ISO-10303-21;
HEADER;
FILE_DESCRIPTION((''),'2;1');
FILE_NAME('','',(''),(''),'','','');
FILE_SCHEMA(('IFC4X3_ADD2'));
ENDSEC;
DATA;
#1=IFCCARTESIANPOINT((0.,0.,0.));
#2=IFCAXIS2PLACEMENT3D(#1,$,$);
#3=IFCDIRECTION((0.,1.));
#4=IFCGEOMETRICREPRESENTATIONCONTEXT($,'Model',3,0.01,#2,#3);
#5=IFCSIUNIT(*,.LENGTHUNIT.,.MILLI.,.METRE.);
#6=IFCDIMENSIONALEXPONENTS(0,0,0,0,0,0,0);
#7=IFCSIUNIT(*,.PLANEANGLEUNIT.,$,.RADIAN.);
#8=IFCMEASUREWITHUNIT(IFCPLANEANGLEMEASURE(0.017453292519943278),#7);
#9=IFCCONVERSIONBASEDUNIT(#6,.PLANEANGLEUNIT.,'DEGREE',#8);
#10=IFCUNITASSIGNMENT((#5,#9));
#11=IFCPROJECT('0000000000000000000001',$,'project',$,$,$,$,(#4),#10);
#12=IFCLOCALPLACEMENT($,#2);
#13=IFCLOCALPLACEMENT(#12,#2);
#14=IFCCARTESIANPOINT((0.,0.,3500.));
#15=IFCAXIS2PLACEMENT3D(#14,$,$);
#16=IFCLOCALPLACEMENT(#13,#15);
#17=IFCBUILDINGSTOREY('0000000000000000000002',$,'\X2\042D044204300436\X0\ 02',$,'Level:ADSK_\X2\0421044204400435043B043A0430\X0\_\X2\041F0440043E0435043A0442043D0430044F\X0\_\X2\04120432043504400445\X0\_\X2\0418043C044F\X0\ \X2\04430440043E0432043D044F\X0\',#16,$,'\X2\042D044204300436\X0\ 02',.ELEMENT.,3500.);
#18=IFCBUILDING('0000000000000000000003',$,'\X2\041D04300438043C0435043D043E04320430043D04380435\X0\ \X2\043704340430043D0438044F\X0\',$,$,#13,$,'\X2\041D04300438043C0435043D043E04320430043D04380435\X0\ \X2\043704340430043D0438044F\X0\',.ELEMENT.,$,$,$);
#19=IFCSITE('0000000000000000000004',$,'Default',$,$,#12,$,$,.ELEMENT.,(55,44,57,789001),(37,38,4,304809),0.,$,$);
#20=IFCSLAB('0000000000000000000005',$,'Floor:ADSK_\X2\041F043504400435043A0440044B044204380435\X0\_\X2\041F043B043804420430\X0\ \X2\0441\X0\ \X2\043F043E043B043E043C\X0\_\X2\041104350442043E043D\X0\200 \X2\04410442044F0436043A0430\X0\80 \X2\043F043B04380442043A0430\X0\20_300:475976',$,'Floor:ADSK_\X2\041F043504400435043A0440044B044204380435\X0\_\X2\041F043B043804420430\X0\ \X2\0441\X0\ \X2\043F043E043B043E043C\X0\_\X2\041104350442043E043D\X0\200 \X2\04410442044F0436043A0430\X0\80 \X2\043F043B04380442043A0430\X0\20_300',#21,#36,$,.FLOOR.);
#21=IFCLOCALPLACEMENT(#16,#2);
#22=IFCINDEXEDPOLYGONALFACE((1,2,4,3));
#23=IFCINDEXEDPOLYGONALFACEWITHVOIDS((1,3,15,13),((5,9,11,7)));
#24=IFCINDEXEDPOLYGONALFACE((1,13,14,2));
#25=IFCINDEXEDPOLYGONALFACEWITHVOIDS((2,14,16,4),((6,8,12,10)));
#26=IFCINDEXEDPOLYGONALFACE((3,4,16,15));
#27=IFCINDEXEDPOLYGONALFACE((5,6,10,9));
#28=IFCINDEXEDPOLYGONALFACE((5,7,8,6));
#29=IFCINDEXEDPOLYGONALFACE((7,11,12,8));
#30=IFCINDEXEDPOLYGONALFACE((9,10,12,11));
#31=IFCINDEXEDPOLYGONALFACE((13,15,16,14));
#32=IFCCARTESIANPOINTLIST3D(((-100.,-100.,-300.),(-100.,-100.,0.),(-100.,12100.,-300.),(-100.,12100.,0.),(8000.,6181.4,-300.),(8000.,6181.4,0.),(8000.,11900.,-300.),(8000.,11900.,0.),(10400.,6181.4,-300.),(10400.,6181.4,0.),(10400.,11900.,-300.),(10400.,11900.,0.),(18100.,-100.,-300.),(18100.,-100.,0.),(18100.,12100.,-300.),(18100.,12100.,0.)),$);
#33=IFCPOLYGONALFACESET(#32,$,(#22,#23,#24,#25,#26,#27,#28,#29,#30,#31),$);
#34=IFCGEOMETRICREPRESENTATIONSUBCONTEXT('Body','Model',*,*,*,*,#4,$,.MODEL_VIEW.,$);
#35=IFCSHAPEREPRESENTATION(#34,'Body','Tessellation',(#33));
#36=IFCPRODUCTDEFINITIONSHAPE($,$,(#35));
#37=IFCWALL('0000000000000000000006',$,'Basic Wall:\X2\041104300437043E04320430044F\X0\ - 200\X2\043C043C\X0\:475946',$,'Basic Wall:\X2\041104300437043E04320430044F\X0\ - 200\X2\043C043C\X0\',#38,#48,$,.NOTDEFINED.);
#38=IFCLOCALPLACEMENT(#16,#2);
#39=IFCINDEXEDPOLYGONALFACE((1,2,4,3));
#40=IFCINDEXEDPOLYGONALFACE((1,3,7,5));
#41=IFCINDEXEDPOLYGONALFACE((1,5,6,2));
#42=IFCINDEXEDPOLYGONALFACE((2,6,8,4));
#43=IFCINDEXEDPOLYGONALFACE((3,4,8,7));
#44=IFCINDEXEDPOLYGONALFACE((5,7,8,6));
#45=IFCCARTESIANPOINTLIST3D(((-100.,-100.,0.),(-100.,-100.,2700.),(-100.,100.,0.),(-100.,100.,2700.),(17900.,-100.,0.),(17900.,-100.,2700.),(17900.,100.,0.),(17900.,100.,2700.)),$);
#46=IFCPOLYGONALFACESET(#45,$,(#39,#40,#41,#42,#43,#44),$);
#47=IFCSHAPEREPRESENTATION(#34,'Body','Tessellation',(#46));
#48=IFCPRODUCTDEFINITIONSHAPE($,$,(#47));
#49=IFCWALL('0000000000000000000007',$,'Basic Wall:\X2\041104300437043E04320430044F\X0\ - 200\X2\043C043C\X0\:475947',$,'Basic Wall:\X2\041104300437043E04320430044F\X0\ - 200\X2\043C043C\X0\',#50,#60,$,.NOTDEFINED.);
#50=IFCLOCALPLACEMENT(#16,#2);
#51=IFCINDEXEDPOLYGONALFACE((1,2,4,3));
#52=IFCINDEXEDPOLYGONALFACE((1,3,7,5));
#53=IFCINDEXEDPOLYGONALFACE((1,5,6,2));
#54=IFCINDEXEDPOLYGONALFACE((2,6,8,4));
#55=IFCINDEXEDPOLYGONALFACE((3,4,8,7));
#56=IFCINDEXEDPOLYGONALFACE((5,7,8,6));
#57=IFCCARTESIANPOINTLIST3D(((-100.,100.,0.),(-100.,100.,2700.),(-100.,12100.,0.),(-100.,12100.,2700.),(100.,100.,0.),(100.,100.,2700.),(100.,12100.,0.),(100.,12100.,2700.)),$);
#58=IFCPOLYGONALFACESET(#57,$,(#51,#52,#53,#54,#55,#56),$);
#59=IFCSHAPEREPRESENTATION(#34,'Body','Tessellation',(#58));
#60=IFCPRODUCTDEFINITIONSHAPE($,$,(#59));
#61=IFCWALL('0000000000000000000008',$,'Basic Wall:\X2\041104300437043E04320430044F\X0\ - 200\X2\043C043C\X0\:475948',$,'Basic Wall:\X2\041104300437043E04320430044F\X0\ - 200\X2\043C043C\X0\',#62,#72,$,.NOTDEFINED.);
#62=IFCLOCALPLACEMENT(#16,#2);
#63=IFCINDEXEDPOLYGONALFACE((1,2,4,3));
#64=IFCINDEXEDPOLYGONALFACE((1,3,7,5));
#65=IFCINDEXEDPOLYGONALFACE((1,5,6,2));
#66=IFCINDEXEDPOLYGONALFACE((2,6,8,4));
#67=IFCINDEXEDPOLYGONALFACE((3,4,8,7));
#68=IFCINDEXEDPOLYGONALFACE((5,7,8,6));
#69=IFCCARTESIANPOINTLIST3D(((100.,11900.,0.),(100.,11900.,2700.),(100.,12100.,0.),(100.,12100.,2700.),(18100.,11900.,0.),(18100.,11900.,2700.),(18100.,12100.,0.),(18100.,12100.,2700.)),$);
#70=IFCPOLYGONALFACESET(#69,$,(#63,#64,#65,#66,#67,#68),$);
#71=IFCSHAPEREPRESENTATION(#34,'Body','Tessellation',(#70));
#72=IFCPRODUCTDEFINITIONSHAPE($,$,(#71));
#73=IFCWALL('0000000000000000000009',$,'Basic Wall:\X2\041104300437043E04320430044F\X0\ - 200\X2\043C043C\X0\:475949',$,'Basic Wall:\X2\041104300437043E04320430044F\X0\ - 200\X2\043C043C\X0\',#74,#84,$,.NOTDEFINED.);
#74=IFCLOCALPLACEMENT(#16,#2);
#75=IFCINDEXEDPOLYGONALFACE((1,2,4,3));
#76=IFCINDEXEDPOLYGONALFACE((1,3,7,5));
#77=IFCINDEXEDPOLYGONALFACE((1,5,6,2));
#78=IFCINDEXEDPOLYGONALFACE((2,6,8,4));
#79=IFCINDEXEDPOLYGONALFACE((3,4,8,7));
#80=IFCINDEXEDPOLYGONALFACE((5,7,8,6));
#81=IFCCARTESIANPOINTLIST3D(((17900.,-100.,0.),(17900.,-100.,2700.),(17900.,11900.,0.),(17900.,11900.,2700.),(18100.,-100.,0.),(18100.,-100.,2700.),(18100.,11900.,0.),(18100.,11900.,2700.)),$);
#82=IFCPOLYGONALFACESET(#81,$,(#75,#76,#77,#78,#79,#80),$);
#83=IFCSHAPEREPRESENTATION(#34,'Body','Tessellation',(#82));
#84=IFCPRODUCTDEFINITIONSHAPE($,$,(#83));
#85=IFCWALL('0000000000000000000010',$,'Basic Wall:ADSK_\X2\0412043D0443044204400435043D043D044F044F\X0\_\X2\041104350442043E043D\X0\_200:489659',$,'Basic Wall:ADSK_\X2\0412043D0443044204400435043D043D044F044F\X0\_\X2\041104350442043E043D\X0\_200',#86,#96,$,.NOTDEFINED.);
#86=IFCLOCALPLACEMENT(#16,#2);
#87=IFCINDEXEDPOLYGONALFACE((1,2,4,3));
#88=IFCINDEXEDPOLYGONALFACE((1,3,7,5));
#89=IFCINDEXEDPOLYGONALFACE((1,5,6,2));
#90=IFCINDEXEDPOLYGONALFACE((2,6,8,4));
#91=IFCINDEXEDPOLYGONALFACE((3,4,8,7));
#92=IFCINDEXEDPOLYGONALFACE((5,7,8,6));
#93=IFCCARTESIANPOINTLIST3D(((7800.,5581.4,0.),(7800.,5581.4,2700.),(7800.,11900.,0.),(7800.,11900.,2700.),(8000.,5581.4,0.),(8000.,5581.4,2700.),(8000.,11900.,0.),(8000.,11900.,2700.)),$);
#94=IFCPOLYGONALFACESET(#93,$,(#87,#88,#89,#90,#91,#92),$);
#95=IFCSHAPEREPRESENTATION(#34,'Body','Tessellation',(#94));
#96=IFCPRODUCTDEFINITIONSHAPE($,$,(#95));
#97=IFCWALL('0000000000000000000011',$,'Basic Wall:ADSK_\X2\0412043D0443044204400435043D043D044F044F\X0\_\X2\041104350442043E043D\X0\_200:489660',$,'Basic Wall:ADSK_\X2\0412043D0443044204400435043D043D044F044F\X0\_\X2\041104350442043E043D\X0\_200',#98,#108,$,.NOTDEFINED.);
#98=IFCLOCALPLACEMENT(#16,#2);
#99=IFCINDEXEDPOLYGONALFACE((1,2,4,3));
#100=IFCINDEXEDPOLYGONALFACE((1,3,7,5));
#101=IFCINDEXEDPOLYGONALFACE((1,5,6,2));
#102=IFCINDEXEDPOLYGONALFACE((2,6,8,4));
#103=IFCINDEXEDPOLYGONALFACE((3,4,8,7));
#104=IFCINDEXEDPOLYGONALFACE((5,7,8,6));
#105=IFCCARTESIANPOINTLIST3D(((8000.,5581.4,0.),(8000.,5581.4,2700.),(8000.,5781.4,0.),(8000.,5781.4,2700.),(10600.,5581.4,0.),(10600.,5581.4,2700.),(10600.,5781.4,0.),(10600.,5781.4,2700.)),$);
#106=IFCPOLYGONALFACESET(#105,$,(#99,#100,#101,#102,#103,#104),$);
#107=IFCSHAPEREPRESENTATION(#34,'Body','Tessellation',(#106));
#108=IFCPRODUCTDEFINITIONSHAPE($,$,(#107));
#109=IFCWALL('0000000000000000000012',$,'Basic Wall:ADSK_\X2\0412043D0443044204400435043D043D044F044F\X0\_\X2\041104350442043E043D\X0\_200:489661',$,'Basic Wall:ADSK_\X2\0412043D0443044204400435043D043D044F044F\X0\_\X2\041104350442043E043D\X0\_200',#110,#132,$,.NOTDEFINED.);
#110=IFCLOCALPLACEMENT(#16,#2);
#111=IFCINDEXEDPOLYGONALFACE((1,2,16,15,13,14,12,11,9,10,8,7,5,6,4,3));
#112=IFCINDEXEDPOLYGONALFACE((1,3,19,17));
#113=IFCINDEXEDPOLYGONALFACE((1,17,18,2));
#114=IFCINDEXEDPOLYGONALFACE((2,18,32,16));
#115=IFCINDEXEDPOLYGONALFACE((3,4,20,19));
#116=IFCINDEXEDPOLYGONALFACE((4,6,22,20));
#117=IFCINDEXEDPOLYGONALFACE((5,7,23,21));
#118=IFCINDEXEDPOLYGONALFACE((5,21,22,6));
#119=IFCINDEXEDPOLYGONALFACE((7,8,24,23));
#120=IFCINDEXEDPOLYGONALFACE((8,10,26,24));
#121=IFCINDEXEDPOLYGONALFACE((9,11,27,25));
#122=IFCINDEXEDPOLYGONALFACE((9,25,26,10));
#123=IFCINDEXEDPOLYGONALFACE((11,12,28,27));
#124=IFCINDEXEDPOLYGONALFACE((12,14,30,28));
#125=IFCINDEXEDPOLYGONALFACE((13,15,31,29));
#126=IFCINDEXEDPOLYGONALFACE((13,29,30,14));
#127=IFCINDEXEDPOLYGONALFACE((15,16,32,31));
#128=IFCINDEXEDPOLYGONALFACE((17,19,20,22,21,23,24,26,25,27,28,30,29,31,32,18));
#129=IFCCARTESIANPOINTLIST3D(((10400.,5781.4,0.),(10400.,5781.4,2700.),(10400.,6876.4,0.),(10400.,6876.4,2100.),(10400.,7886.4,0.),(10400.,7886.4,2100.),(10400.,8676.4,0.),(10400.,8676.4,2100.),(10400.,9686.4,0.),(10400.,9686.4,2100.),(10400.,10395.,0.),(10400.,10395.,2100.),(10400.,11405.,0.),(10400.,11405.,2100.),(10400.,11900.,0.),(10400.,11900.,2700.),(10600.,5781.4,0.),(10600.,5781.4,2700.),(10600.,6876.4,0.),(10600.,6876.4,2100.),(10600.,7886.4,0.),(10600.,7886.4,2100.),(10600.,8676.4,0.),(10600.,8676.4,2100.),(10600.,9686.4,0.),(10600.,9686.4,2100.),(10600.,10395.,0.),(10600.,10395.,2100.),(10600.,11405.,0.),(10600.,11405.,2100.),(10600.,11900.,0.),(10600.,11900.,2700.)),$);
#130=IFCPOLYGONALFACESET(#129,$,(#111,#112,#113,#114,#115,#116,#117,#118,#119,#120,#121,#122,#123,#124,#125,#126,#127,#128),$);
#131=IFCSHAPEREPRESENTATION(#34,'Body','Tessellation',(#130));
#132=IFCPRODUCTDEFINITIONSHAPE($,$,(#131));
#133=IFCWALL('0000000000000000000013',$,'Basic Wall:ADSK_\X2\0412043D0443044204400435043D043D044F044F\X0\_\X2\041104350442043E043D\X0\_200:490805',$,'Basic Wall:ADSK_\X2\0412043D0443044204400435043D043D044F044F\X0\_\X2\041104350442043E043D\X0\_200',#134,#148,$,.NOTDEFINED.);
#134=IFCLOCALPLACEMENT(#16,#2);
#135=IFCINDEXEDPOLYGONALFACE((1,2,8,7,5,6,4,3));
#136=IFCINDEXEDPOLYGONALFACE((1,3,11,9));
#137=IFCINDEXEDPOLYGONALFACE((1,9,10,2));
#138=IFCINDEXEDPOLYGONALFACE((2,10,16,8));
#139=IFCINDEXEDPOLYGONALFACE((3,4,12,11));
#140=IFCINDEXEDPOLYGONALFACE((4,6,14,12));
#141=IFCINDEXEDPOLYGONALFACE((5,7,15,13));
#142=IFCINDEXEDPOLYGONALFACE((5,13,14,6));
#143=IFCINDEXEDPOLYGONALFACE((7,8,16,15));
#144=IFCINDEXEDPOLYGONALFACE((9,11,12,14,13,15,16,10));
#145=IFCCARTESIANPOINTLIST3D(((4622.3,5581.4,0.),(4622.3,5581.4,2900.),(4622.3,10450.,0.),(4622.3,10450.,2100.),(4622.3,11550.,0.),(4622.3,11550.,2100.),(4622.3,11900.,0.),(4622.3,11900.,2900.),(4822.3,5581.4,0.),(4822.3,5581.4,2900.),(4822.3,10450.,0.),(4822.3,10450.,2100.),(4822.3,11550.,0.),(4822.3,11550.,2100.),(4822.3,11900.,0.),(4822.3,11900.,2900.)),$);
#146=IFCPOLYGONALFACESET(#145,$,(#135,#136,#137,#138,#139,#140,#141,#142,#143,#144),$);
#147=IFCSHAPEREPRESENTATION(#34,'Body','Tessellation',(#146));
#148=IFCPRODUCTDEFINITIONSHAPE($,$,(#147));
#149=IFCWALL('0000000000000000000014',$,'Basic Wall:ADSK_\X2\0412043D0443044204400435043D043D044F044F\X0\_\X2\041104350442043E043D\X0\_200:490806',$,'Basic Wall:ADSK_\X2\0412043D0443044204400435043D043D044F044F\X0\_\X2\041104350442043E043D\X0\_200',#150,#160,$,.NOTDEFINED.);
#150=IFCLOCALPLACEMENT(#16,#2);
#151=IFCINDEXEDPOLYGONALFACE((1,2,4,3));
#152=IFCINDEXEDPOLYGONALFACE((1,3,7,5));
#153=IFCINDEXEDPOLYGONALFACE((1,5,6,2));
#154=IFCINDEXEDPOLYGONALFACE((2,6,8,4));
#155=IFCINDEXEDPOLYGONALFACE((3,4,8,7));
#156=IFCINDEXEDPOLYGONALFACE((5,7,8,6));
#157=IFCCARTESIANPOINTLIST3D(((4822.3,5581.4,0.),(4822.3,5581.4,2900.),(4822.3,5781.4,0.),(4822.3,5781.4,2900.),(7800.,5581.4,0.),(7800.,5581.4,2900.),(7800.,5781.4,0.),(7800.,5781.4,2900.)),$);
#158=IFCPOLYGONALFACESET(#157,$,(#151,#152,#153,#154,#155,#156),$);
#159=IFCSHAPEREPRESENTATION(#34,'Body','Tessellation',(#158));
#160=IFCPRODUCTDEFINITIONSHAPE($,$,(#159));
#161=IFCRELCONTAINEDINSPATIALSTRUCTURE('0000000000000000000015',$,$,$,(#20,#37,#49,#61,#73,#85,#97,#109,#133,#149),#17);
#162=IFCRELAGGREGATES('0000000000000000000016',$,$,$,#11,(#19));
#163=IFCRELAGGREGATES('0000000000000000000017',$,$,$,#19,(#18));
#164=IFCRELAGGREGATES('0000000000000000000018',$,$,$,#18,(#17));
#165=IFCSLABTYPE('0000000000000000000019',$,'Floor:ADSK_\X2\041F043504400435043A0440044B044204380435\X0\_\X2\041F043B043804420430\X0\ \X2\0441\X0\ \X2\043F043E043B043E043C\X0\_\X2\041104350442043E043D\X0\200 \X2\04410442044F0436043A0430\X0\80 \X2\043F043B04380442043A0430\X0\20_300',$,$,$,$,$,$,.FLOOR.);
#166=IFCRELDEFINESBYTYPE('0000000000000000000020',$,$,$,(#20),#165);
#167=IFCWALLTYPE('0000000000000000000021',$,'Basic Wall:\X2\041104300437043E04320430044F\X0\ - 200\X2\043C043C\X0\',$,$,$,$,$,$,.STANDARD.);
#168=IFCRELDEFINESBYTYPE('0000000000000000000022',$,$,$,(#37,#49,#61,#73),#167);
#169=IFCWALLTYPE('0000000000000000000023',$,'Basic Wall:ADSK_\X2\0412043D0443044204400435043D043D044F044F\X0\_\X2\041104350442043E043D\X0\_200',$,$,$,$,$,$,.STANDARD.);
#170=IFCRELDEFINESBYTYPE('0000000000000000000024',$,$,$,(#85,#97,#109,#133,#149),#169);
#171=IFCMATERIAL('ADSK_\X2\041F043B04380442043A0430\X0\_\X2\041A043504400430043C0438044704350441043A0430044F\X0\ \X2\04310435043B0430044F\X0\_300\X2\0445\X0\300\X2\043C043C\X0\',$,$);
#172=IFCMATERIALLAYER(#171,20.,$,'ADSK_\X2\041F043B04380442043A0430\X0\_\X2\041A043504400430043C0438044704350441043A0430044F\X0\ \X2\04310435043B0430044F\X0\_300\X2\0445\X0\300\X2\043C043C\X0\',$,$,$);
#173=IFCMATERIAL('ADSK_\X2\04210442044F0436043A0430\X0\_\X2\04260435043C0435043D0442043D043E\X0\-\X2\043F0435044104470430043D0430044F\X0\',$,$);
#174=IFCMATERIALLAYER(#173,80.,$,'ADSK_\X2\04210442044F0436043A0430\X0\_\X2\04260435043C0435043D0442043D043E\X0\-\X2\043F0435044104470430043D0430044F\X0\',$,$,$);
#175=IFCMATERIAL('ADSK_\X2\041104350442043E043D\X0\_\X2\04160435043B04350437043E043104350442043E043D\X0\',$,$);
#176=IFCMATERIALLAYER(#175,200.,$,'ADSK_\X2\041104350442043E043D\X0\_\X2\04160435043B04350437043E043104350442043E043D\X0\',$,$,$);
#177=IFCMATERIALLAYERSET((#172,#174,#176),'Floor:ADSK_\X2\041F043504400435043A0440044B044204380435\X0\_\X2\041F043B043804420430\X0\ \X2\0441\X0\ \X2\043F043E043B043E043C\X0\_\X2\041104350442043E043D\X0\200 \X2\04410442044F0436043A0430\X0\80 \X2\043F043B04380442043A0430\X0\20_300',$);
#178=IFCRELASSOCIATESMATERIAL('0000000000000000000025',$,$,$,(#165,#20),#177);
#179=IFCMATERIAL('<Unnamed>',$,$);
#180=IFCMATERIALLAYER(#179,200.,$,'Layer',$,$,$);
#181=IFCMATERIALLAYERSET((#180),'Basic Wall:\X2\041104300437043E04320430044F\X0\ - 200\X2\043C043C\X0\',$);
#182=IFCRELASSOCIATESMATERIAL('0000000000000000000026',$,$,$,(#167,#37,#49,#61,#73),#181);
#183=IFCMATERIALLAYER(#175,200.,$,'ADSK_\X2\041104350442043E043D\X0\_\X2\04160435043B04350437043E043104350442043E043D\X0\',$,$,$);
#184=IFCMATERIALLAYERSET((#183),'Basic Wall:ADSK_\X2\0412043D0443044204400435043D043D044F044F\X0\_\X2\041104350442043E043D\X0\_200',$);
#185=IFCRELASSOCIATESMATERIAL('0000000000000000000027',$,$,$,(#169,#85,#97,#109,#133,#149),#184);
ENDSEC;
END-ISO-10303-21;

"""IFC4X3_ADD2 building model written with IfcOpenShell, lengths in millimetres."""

from ifc_helpers import new_model, entity, si_unit, converted_unit, direction, frame, frame_2d, origin, origin_2d_with_axis, place, context, subcontext, project, spatial, rectangle, extrude, boolean, material, layer, layer_set, layer_usage, type_object, element, save


model = new_model("IFC4X3_ADD2")

# Units and contexts
model_context = context("Model", 3, precision=0.01, world=origin(), true_north=direction((0.0, 1.0)))
body_context = subcontext(model_context, "Body", "Model", "MODEL_VIEW")
ifc_project = project(units=[si_unit("LENGTHUNIT", "METRE", prefix="MILLI"), converted_unit("PLANEANGLEUNIT", "DEGREE", entity("IfcPlaneAngleMeasure", 0.017453292519943278), si_unit("PLANEANGLEUNIT", "RADIAN"), dimensions=[0, 0, 0, 0, 0, 0, 0])], contexts=[model_context])

# Site, building, storey
site_placement = place(None, origin())
site = spatial("IfcSite", under=ifc_project, at=site_placement, Name="Default", CompositionType="ELEMENT", RefLatitude=(55, 44, 57, 789001), RefLongitude=(37, 38, 4, 304809), RefElevation=0.0)
building_placement = place(site_placement, origin())
building = spatial("IfcBuilding", under=site, at=building_placement, Name="Наименование здания", LongName="Наименование здания", CompositionType="ELEMENT")
storey_placement = place(building_placement, frame((0.0, 0.0, 3500.0)))
storey = spatial("IfcBuildingStorey", under=building, at=storey_placement, Name="Этаж 02", ObjectType="Level:ADSK_Стрелка_Проектная_Вверх_Имя уровня", LongName="Этаж 02", CompositionType="ELEMENT", Elevation=3500.0)

# Slab, opening
ifc_material_1 = material(Name="ADSK_Плитка_Керамическая белая_300х300мм")
ifc_layer_1 = layer(ifc_material_1, 20.0, Name="ADSK_Плитка_Керамическая белая_300х300мм")
ifc_material_2 = material(Name="ADSK_Стяжка_Цементно-песчаная")
ifc_layer_2 = layer(ifc_material_2, 80.0, Name="ADSK_Стяжка_Цементно-песчаная")
ifc_material_3 = material(Name="ADSK_Бетон_Железобетон")
ifc_layer_3 = layer(ifc_material_3, 200.0, Name="ADSK_Бетон_Железобетон")
ifc_layer_set_1 = layer_set([ifc_layer_1, ifc_layer_2, ifc_layer_3], Name="Floor:ADSK_Перекрытие_Плита с полом_Бетон200 стяжка80 плитка20_300")
ifc_layer_usage = layer_usage(ifc_layer_set_1, "AXIS3", "POSITIVE", 0.0)
slab_type = type_object("IfcSlabType", Name="Floor:ADSK_Перекрытие_Плита с полом_Бетон200 стяжка80 плитка20_300", PredefinedType="FLOOR", material=ifc_layer_set_1)
slab_placement = place(storey_placement, origin())
slab = element("IfcSlab", 1, at=slab_placement, inside=storey, type_object=slab_type, material=ifc_layer_usage, Name="Floor:ADSK_Перекрытие_Плита с полом_Бетон200 стяжка80 плитка20_300:475976", ObjectType="Floor:ADSK_Перекрытие_Плита с полом_Бетон200 стяжка80 плитка20_300", PredefinedType="FLOOR", context=body_context, shape_type="SweptSolid", body=[
    boolean("DIFFERENCE", extrude(rectangle(XDim=12200.0, YDim=18200.0, at=origin_2d_with_axis()), frame((9000.0, 6000.0, 0.0), z_axis=(0.0, 0.0, -1.0), x_axis=(0.0, 1.0, 0.0)), (0.0, 0.0, 1.0), 300.0), extrude(rectangle(XDim=5718.6, YDim=2400.0, at=frame_2d((0.0, 0.0), x_axis=(1.0, 0.0))), frame((9200.0, 9040.7, -300.0), z_axis=(0.0, 0.0, 1.0), x_axis=(0.0, 1.0, 0.0)), (0.0, 0.0, 1.0), 300.0)),
])
opening_1_placement = place(slab_placement, origin())
element("IfcOpeningElement", 2, at=opening_1_placement, cuts=slab, PredefinedType="OPENING", context=body_context, shape_type="SweptSolid", body=[
    extrude(rectangle(XDim=2400.0, YDim=5718.6, at=frame_2d((0.0, 0.0), x_axis=(1.0, 0.0))), frame((9200.0, 9040.7, -300.0), z_axis=(0.0, 0.0, 1.0), x_axis=(-1.0, 0.0, 0.0)), (0.0, 0.0, 1.0), 300.0),
])

# Walls
ifc_material_4 = material(Name="<Unnamed>")
ifc_layer_4 = layer(ifc_material_4, 200.0, Name="Layer")
ifc_layer_set_2 = layer_set([ifc_layer_4], Name="Basic Wall:Базовая - 200мм")
wall_type_1 = type_object("IfcWallType", Name="Basic Wall:Базовая - 200мм", PredefinedType="STANDARD", material=ifc_layer_set_2)
wall_1_placement = place(storey_placement, frame((-100.0, 0.0, 0.0)))
element("IfcWall", 3, at=wall_1_placement, inside=storey, type_object=wall_type_1, material=ifc_layer_set_2, Name="Basic Wall:Базовая - 200мм:475946", ObjectType="Basic Wall:Базовая - 200мм", PredefinedType="NOTDEFINED", context=body_context, shape_type="SweptSolid", body=[
    extrude(rectangle(XDim=18000.0, YDim=200.0, at=frame_2d((9000.0, 0.0), x_axis=(-1.0, 0.0))), origin(), (0.0, 0.0, 1.0), 2700.0),
])
wall_2_placement = place(storey_placement, frame((0.0, 12100.0, 0.0), z_axis=(0.0, 0.0, 1.0), x_axis=(0.0, -1.0, 0.0)))
element("IfcWall", 4, at=wall_2_placement, inside=storey, type_object=wall_type_1, material=ifc_layer_set_2, Name="Basic Wall:Базовая - 200мм:475947", ObjectType="Basic Wall:Базовая - 200мм", PredefinedType="NOTDEFINED", context=body_context, shape_type="SweptSolid", body=[
    extrude(rectangle(XDim=12000.0, YDim=200.0, at=frame_2d((6000.0, 0.0), x_axis=(-1.0, 0.0))), origin(), (0.0, 0.0, 1.0), 2700.0),
])
wall_3_placement = place(storey_placement, frame((18100.0, 12000.0, 0.0), z_axis=(0.0, 0.0, 1.0), x_axis=(-1.0, 0.0, 0.0)))
element("IfcWall", 5, at=wall_3_placement, inside=storey, type_object=wall_type_1, material=ifc_layer_set_2, Name="Basic Wall:Базовая - 200мм:475948", ObjectType="Basic Wall:Базовая - 200мм", PredefinedType="NOTDEFINED", context=body_context, shape_type="SweptSolid", body=[
    extrude(rectangle(XDim=18000.0, YDim=200.0, at=frame_2d((9000.0, 0.0), x_axis=(-1.0, 0.0))), origin(), (0.0, 0.0, 1.0), 2700.0),
])
wall_4_placement = place(storey_placement, frame((18000.0, -100.0, 0.0), z_axis=(0.0, 0.0, 1.0), x_axis=(0.0, 1.0, 0.0)))
element("IfcWall", 6, at=wall_4_placement, inside=storey, type_object=wall_type_1, material=ifc_layer_set_2, Name="Basic Wall:Базовая - 200мм:475949", ObjectType="Basic Wall:Базовая - 200мм", PredefinedType="NOTDEFINED", context=body_context, shape_type="SweptSolid", body=[
    extrude(rectangle(XDim=12000.0, YDim=200.0, at=frame_2d((6000.0, 0.0), x_axis=(-1.0, 0.0))), origin(), (0.0, 0.0, 1.0), 2700.0),
])
ifc_layer_5 = layer(ifc_material_3, 200.0, Name="ADSK_Бетон_Железобетон")
ifc_layer_set_3 = layer_set([ifc_layer_5], Name="Basic Wall:ADSK_Внутренняя_Бетон_200")
wall_type_2 = type_object("IfcWallType", Name="Basic Wall:ADSK_Внутренняя_Бетон_200", PredefinedType="STANDARD", material=ifc_layer_set_3)
wall_5_placement = place(storey_placement, frame((7900.0, 5581.4, 0.0), z_axis=(0.0, 0.0, 1.0), x_axis=(0.0, 1.0, 0.0)))
element("IfcWall", 7, at=wall_5_placement, inside=storey, type_object=wall_type_2, material=ifc_layer_set_3, Name="Basic Wall:ADSK_Внутренняя_Бетон_200:489659", ObjectType="Basic Wall:ADSK_Внутренняя_Бетон_200", PredefinedType="NOTDEFINED", context=body_context, shape_type="SweptSolid", body=[
    extrude(rectangle(XDim=6318.6, YDim=200.0, at=frame_2d((3159.3, 0.0), x_axis=(-1.0, 0.0))), origin(), (0.0, 0.0, 1.0), 2700.0),
])
wall_6_placement = place(storey_placement, frame((8000.0, 5681.4, 0.0)))
element("IfcWall", 8, at=wall_6_placement, inside=storey, type_object=wall_type_2, material=ifc_layer_set_3, Name="Basic Wall:ADSK_Внутренняя_Бетон_200:489660", ObjectType="Basic Wall:ADSK_Внутренняя_Бетон_200", PredefinedType="NOTDEFINED", context=body_context, shape_type="SweptSolid", body=[
    extrude(rectangle(XDim=2600.0, YDim=200.0, at=frame_2d((1300.0, 0.0), x_axis=(-1.0, 0.0))), origin(), (0.0, 0.0, 1.0), 2700.0),
])

# Wall, openings
wall_7_placement = place(storey_placement, frame((10500.0, 5781.4, 0.0), z_axis=(0.0, 0.0, 1.0), x_axis=(0.0, 1.0, 0.0)))
wall_7 = element("IfcWall", 9, at=wall_7_placement, inside=storey, type_object=wall_type_2, material=ifc_layer_set_3, Name="Basic Wall:ADSK_Внутренняя_Бетон_200:489661", ObjectType="Basic Wall:ADSK_Внутренняя_Бетон_200", PredefinedType="NOTDEFINED", context=body_context, shape_type="SweptSolid", body=[
    extrude(rectangle(XDim=6118.6, YDim=200.0, at=frame_2d((3059.3, 0.0), x_axis=(-1.0, 0.0))), origin(), (0.0, 0.0, 1.0), 2700.0),
])
opening_2_placement = place(wall_7_placement, frame((-5781.4, 10500.0, 0.0), z_axis=(0.0, 0.0, 1.0), x_axis=(0.0, -1.0, 0.0)))
element("IfcOpeningElement", 10, at=opening_2_placement, cuts=wall_7, PredefinedType="OPENING", context=body_context, shape_type="SweptSolid", body=[
    extrude(rectangle(XDim=2100.0, YDim=1010.0, at=frame_2d((0.0, 0.0), x_axis=(1.0, 0.0))), frame((10600.0, 7381.4, 1050.0), z_axis=(-1.0, 0.0, 0.0), x_axis=(0.0, 0.0, -1.0)), (0.0, 0.0, 1.0), 200.0),
])
opening_3_placement = place(wall_7_placement, frame((-5781.4, 10500.0, 0.0), z_axis=(0.0, 0.0, 1.0), x_axis=(0.0, -1.0, 0.0)))
element("IfcOpeningElement", 11, at=opening_3_placement, cuts=wall_7, PredefinedType="OPENING", context=body_context, shape_type="SweptSolid", body=[
    extrude(rectangle(XDim=2100.0, YDim=1010.0, at=frame_2d((0.0, 0.0), x_axis=(1.0, 0.0))), frame((10600.0, 9181.4, 1050.0), z_axis=(-1.0, 0.0, 0.0), x_axis=(0.0, 0.0, -1.0)), (0.0, 0.0, 1.0), 200.0),
])
opening_4_placement = place(wall_7_placement, frame((-5781.4, 10500.0, 0.0), z_axis=(0.0, 0.0, 1.0), x_axis=(0.0, -1.0, 0.0)))
element("IfcOpeningElement", 12, at=opening_4_placement, cuts=wall_7, PredefinedType="OPENING", context=body_context, shape_type="SweptSolid", body=[
    extrude(rectangle(XDim=2100.0, YDim=1010.0, at=origin_2d_with_axis()), frame((10600.0, 10900.0, 1050.0), z_axis=(-1.0, 0.0, 0.0), x_axis=(0.0, 0.0, -1.0)), (0.0, 0.0, 1.0), 200.0),
])

# Wall, opening
wall_8_placement = place(storey_placement, frame((4722.3, 11900.0, 0.0), z_axis=(0.0, 0.0, 1.0), x_axis=(0.0, -1.0, 0.0)))
wall_8 = element("IfcWall", 13, at=wall_8_placement, inside=storey, type_object=wall_type_2, material=ifc_layer_set_3, Name="Basic Wall:ADSK_Внутренняя_Бетон_200:490805", ObjectType="Basic Wall:ADSK_Внутренняя_Бетон_200", PredefinedType="NOTDEFINED", context=body_context, shape_type="SweptSolid", body=[
    extrude(rectangle(XDim=6318.6, YDim=200.0, at=frame_2d((3159.3, 0.0), x_axis=(-1.0, 0.0))), origin(), (0.0, 0.0, 1.0), 2900.0),
])
opening_5_placement = place(wall_8_placement, frame((11900.0, -4722.3, 0.0), z_axis=(0.0, 0.0, 1.0), x_axis=(0.0, 1.0, 0.0)))
element("IfcOpeningElement", 14, at=opening_5_placement, cuts=wall_8, PredefinedType="OPENING", context=body_context, shape_type="SweptSolid", body=[
    extrude(rectangle(XDim=2100.0, YDim=1100.0, at=frame_2d((0.0, 0.0), x_axis=(0.0, 1.0))), frame((4122.3, 11000.0, 1050.0), z_axis=(1.0, 0.0, 0.0), x_axis=(0.0, -1.0, 0.0)), (0.0, 0.0, 1.0), 1200.0),
])

# Wall
wall_9_placement = place(storey_placement, frame((4822.3, 5681.4, 0.0)))
element("IfcWall", 15, at=wall_9_placement, inside=storey, type_object=wall_type_2, material=ifc_layer_set_3, Name="Basic Wall:ADSK_Внутренняя_Бетон_200:490806", ObjectType="Basic Wall:ADSK_Внутренняя_Бетон_200", PredefinedType="NOTDEFINED", context=body_context, shape_type="SweptSolid", body=[
    extrude(rectangle(XDim=2977.7, YDim=200.0, at=frame_2d((1488.9, 0.0), x_axis=(-1.0, 0.0))), origin(), (0.0, 0.0, 1.0), 2900.0),
])

save(model, "model.ifc")
